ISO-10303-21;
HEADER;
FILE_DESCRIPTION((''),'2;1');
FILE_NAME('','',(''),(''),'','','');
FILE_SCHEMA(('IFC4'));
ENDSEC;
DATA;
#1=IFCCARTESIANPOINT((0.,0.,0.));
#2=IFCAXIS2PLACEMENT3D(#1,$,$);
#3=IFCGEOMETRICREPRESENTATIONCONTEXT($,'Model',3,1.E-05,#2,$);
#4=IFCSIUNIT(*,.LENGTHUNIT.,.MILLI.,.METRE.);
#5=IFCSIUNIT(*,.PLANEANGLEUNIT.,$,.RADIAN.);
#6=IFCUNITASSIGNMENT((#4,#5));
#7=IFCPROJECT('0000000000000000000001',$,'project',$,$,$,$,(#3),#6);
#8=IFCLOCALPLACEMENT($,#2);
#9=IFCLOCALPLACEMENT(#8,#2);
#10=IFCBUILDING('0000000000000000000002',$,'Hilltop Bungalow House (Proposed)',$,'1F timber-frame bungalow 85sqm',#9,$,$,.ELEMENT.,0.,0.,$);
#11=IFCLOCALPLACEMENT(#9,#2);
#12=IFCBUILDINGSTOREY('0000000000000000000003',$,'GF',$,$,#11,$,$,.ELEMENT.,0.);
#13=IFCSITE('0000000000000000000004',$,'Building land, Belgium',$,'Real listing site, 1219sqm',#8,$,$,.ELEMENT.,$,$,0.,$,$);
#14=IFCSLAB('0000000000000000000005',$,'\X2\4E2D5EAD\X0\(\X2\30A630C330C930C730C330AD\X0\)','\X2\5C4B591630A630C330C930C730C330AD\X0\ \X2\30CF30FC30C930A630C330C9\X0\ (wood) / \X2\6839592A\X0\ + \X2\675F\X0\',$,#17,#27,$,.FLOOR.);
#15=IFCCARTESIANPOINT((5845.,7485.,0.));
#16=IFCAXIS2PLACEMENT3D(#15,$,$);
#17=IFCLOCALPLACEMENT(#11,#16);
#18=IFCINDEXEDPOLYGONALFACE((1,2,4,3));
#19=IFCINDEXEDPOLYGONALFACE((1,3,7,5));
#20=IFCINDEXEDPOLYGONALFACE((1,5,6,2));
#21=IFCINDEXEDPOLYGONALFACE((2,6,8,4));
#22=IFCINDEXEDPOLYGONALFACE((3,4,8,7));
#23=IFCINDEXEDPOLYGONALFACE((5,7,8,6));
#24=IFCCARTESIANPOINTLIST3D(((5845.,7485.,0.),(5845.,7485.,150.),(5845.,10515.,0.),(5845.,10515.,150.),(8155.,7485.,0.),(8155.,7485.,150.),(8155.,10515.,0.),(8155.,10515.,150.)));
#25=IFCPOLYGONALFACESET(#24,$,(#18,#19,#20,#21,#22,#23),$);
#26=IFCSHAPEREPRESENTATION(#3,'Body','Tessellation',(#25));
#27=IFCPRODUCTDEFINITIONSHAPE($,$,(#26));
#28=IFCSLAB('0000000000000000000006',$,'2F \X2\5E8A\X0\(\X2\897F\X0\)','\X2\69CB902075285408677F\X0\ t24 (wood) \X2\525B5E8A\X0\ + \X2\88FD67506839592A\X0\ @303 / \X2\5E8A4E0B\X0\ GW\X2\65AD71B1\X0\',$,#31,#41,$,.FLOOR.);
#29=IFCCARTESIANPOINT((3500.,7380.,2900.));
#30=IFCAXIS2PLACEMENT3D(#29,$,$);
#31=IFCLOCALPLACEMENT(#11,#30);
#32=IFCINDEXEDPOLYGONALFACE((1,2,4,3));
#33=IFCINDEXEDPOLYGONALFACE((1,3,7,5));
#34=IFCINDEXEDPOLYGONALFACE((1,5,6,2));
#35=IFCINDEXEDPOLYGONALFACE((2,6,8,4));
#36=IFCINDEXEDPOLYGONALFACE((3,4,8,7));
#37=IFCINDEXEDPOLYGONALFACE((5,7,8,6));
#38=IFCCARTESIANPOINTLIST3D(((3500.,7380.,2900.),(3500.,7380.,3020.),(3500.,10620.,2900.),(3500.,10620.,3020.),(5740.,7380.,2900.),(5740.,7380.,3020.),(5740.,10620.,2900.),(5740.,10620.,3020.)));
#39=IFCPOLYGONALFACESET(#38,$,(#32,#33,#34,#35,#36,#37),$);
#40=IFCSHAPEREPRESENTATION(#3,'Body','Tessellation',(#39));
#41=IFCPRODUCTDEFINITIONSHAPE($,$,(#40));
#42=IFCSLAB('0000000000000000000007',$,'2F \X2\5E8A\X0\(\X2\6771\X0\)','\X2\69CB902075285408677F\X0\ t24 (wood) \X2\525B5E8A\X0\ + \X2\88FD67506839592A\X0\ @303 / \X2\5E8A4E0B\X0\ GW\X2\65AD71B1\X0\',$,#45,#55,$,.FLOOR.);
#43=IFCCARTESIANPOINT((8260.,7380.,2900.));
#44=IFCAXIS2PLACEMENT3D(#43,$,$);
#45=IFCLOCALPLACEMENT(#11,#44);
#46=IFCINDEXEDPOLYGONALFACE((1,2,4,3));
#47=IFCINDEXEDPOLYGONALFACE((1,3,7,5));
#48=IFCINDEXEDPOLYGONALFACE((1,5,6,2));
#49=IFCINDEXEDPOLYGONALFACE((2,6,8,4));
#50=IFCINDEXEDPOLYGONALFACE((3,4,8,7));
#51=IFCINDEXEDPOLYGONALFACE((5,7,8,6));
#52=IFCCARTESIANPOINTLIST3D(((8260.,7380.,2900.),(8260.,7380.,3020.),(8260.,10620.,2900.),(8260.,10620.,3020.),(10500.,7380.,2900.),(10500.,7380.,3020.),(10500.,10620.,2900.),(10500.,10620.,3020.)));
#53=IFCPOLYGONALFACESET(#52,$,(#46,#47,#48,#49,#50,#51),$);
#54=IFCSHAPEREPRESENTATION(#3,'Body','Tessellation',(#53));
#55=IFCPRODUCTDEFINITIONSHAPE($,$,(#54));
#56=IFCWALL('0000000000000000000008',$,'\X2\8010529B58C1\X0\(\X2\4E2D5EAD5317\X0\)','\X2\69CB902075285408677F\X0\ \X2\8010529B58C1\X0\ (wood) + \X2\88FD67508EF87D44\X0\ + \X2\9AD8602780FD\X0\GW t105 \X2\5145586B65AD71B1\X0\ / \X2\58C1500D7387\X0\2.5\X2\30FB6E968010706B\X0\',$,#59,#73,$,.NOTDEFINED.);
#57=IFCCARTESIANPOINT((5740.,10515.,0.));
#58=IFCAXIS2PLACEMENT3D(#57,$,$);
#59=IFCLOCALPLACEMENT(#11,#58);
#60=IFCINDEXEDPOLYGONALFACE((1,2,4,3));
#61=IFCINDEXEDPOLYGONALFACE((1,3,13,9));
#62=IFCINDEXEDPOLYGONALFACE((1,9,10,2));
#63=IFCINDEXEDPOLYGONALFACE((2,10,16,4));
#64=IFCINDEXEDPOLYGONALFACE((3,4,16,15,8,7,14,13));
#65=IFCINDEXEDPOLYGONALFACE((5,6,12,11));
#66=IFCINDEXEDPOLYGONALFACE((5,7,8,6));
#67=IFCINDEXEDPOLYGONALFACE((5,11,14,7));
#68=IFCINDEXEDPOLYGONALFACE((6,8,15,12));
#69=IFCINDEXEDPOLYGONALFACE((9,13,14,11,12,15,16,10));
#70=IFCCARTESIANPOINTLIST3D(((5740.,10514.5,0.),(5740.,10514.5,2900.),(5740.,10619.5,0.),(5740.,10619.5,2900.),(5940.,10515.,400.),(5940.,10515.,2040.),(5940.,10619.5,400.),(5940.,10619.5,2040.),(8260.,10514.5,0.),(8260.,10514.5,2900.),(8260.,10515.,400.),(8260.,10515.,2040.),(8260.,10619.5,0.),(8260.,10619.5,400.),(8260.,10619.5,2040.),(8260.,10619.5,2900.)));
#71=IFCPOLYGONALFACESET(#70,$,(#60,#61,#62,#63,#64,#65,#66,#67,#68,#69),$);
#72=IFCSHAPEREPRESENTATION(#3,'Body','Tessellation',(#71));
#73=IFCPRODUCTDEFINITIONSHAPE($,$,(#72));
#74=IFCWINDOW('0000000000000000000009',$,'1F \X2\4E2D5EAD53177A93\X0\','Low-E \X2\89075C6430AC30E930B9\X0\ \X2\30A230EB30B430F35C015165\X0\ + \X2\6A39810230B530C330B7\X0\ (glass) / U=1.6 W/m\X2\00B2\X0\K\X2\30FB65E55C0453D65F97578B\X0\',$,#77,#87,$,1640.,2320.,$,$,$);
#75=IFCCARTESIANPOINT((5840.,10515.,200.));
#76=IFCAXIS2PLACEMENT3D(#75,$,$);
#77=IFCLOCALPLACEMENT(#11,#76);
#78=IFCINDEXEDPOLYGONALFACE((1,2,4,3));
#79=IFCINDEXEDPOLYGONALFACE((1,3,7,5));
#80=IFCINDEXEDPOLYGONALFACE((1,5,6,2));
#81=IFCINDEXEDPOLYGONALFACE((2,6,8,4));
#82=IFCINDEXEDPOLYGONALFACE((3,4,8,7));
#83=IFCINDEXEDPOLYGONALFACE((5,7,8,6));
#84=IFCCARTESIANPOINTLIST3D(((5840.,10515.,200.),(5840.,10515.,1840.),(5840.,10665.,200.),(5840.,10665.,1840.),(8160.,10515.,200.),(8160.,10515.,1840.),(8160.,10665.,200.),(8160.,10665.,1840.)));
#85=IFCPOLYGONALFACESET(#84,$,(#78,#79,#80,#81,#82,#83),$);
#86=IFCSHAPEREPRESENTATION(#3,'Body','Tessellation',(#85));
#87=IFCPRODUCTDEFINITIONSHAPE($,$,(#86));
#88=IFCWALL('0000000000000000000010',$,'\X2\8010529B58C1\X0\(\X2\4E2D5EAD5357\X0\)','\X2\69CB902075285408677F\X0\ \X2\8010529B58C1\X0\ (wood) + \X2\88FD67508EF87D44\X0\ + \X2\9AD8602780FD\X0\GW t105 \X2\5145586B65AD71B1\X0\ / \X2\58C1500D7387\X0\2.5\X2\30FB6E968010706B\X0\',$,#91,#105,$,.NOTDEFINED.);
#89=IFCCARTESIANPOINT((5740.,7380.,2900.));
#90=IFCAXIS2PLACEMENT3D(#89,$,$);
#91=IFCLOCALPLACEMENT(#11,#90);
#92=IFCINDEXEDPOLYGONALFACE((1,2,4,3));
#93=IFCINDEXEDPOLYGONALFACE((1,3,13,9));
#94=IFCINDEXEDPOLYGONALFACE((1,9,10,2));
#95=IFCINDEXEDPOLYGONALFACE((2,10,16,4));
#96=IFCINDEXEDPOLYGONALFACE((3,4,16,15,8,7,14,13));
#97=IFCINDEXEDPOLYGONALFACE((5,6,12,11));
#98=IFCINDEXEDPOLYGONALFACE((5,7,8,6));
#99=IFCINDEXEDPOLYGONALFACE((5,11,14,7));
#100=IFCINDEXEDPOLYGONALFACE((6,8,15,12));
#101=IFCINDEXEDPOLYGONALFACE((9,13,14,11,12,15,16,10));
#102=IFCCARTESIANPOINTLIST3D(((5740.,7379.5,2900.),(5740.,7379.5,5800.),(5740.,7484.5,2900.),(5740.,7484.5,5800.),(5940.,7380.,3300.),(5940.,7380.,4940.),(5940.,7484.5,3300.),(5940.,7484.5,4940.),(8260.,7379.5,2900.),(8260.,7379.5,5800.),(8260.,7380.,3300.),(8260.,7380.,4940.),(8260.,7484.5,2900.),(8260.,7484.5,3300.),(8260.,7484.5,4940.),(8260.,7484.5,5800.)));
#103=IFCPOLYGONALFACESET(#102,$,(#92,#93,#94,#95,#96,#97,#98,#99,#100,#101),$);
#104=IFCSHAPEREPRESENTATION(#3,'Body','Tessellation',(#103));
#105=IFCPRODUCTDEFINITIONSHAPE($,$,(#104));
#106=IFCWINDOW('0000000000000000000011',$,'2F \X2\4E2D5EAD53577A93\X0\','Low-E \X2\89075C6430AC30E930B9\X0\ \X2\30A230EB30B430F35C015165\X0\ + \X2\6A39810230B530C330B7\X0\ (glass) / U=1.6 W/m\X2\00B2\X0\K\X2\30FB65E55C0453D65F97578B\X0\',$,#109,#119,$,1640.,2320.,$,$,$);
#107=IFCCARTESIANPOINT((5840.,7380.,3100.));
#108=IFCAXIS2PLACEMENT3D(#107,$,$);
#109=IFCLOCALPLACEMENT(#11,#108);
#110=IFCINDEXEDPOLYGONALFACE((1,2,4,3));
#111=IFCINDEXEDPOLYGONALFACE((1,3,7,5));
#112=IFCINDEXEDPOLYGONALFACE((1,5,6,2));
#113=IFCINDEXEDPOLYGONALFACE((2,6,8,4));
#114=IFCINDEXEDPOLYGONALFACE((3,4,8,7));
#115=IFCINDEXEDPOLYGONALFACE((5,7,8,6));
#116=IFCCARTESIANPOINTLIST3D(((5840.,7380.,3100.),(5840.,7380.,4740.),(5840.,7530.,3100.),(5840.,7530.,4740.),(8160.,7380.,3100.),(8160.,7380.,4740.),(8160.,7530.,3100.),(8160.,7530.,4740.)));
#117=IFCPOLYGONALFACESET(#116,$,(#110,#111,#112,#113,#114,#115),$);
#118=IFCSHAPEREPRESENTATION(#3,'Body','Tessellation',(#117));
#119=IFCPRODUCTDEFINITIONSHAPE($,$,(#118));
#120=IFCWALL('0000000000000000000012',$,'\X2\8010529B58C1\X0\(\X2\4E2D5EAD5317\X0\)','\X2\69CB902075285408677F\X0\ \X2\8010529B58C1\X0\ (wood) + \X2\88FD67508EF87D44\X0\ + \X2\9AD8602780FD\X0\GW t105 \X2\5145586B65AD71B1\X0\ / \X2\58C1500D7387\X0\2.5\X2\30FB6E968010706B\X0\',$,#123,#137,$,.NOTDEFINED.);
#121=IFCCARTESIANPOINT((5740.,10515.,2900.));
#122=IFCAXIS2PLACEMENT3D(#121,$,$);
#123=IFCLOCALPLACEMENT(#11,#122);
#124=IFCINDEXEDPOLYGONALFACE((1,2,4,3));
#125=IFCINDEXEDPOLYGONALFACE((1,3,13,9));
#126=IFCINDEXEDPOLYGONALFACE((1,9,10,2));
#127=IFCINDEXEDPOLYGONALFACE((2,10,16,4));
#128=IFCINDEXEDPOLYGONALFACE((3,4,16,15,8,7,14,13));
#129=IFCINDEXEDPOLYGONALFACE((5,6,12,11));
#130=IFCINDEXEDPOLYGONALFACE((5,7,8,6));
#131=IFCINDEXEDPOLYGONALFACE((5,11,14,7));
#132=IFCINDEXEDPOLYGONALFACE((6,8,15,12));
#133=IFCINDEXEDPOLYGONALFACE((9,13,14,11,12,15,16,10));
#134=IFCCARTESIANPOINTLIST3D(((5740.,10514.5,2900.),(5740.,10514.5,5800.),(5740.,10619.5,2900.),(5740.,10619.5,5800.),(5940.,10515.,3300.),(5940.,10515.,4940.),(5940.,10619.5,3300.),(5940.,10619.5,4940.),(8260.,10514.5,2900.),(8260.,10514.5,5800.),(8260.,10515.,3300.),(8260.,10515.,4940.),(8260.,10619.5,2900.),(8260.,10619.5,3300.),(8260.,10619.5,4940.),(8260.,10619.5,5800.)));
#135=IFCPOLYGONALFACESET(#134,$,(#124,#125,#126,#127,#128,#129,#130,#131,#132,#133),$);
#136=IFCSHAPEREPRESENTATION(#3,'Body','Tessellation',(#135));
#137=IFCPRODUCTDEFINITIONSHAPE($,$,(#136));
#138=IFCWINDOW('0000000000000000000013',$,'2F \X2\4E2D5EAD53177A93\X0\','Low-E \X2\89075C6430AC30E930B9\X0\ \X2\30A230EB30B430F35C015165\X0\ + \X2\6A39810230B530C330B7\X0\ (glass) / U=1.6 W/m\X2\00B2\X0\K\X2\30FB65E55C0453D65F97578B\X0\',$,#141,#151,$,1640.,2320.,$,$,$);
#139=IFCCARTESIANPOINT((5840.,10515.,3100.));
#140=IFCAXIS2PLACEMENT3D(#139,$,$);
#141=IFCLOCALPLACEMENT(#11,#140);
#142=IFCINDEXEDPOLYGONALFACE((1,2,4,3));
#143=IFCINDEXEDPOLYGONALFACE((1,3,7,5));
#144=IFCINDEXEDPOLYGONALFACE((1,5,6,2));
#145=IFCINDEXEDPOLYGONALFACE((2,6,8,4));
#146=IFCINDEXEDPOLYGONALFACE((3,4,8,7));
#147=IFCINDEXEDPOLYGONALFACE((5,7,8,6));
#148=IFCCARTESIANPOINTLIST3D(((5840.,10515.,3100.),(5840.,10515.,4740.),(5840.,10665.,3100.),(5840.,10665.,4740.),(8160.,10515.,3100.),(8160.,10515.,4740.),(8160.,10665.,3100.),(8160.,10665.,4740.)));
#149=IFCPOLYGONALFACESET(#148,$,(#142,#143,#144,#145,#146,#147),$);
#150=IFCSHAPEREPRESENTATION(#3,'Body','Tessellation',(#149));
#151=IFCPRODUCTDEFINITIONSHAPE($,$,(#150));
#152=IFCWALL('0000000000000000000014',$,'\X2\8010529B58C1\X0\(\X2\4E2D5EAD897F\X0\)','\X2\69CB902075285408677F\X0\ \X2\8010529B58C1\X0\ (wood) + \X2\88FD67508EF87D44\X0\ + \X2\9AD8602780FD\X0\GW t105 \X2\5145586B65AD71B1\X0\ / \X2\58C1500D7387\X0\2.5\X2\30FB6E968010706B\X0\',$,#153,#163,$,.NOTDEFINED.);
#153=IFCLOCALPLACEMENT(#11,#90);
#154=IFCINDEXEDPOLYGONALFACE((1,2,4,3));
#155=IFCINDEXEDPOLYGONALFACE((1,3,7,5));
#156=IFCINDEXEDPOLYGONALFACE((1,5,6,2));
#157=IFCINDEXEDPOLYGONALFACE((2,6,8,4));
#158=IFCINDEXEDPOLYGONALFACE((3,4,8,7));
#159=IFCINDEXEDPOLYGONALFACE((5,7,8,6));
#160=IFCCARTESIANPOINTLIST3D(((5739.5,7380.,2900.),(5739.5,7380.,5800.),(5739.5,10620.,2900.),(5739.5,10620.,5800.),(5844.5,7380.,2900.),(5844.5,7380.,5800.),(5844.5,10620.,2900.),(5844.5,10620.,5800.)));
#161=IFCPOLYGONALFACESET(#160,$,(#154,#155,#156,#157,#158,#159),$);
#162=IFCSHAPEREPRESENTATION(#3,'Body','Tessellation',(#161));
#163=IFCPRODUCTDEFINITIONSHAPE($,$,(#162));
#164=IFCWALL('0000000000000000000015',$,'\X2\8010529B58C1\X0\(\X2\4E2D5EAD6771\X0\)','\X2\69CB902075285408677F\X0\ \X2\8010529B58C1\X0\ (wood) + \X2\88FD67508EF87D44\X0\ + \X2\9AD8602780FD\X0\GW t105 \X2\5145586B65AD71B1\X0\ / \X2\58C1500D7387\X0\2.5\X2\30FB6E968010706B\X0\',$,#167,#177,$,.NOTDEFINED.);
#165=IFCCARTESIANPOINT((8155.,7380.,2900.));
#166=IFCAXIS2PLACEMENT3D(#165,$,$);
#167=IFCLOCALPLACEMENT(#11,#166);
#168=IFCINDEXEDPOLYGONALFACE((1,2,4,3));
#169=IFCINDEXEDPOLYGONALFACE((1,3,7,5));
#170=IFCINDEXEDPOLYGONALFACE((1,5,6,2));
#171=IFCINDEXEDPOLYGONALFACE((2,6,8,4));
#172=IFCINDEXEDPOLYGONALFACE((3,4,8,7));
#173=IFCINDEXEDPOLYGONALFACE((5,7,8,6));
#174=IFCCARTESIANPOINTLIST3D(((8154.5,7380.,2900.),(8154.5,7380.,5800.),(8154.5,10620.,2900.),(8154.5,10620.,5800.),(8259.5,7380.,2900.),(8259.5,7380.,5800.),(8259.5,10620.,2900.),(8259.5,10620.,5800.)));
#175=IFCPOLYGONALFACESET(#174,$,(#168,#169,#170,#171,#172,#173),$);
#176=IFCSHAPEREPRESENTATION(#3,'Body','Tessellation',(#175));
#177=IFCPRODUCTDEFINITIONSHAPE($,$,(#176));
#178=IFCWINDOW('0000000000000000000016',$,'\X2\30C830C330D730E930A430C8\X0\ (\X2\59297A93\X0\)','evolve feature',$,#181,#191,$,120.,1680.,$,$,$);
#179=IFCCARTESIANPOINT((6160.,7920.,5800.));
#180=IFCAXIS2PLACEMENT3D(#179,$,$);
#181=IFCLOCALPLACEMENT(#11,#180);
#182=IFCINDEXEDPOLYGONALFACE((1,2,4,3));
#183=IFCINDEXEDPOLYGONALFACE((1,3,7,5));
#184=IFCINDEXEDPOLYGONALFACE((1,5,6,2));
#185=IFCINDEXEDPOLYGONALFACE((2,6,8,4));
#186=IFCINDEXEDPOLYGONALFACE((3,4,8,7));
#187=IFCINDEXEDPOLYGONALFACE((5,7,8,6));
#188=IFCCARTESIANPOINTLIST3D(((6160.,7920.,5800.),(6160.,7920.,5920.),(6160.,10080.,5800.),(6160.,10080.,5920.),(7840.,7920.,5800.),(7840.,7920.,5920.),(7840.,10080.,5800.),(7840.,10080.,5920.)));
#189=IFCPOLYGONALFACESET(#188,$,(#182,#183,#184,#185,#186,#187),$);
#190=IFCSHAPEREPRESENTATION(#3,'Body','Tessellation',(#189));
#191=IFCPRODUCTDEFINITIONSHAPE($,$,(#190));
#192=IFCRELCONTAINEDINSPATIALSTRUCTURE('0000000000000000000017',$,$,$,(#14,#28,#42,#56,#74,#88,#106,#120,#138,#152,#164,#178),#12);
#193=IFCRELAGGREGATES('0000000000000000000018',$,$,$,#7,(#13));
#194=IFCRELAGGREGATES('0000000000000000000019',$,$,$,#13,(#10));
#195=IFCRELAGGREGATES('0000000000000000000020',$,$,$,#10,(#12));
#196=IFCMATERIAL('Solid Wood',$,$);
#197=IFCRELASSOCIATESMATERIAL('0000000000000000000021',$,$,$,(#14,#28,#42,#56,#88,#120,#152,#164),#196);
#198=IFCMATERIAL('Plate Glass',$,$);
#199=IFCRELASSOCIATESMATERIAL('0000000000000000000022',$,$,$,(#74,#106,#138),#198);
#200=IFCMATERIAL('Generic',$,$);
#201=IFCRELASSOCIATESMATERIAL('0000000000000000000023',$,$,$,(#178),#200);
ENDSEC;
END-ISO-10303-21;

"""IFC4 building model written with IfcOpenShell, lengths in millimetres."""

from ifc_helpers import new_model, si_unit, frame, frame_2d, origin, place, context, project, spatial, rectangle, extrude, material, element, fill, save


model = new_model("IFC4")

# Units and contexts
model_context = context("Model", 3, precision=1e-05, world=origin())
ifc_project = project(units=[si_unit("LENGTHUNIT", "METRE", prefix="MILLI"), si_unit("PLANEANGLEUNIT", "RADIAN")], contexts=[model_context])

# Site, building, storey
site_placement = place(None, origin())
site = spatial("IfcSite", under=ifc_project, at=site_placement, Name="Building land, Belgium", ObjectType="Real listing site, 1219sqm", CompositionType="ELEMENT", RefElevation=0.0)
building_placement = place(site_placement, origin())
building = spatial("IfcBuilding", under=site, at=building_placement, Name="Hilltop Bungalow House (Proposed)", ObjectType="1F timber-frame bungalow 85sqm", CompositionType="ELEMENT", ElevationOfRefHeight=0.0, ElevationOfTerrain=0.0)
storey_placement = place(building_placement, origin())
storey = spatial("IfcBuildingStorey", under=building, at=storey_placement, Name="GF", CompositionType="ELEMENT", Elevation=0.0)

# Slabs
ifc_material_1 = material(Name="Solid Wood")
slab_1_placement = place(storey_placement, frame((5845.0, 7485.0, 0.0)))
element("IfcSlab", 1, at=slab_1_placement, inside=storey, material=ifc_material_1, Name="中庭(ウッドデッキ)", Description="屋外ウッドデッキ ハードウッド (wood) / 根太 + 束", PredefinedType="FLOOR", context=model_context, shape_type="SweptSolid", body=[
    extrude(rectangle(XDim=2310.0, YDim=3030.0, at=frame_2d((1155.0, 1515.0))), frame((5845.0, 7485.0, 0.0)), (0.0, 0.0, 1.0), 150.0),
])
slab_2_placement = place(storey_placement, frame((3500.0, 7380.0, 2900.0)))
element("IfcSlab", 2, at=slab_2_placement, inside=storey, material=ifc_material_1, Name="2F 床(西)", Description="構造用合板 t24 (wood) 剛床 + 製材根太 @303 / 床下 GW断熱", PredefinedType="FLOOR", context=model_context, shape_type="SweptSolid", body=[
    extrude(rectangle(XDim=2240.0, YDim=3240.0, at=frame_2d((1120.0, 1620.0))), frame((3500.0, 7380.0, 2900.0)), (0.0, 0.0, 1.0), 120.0),
])
slab_3_placement = place(storey_placement, frame((8260.0, 7380.0, 2900.0)))
element("IfcSlab", 3, at=slab_3_placement, inside=storey, material=ifc_material_1, Name="2F 床(東)", Description="構造用合板 t24 (wood) 剛床 + 製材根太 @303 / 床下 GW断熱", PredefinedType="FLOOR", context=model_context, shape_type="SweptSolid", body=[
    extrude(rectangle(XDim=2240.0, YDim=3240.0, at=frame_2d((1120.0, 1620.0))), frame((8260.0, 7380.0, 2900.0)), (0.0, 0.0, 1.0), 120.0),
])

# Walls, openings, windows
wall_1_placement = place(storey_placement, frame((5740.0, 10515.0, 0.0)))
wall_1 = element("IfcWall", 4, at=wall_1_placement, inside=storey, material=ifc_material_1, Name="耐力壁(中庭北)", Description="構造用合板 耐力壁 (wood) + 製材軸組 + 高性能GW t105 充填断熱 / 壁倍率2.5・準耐火", PredefinedType="NOTDEFINED", context=model_context, shape_type="SweptSolid", body=[
    extrude(rectangle(XDim=2520.0, YDim=105.0, at=frame_2d((1260.0, 52.0))), frame((5740.0, 10515.0, 0.0)), (0.0, 0.0, 1.0), 2900.0),
])
opening_1_placement = place(storey_placement, frame((5840.0, 10515.0, 200.0)))
opening_1 = element("IfcOpeningElement", 5, at=opening_1_placement, cuts=wall_1, PredefinedType="NOTDEFINED", context=model_context, shape_type="SweptSolid", body=[
    extrude(rectangle(XDim=2320.0, YDim=150.0, at=frame_2d((1160.0, 75.0))), frame((5840.0, 10515.0, 200.0)), (0.0, 0.0, 1.0), 1640.0),
])
ifc_material_2 = material(Name="Plate Glass")
window_1_placement = place(storey_placement, frame((5840.0, 10515.0, 200.0)))
window_1 = element("IfcWindow", 6, at=window_1_placement, inside=storey, material=ifc_material_2, Name="1F 中庭北窓", Description="Low-E 複層ガラス アルゴン封入 + 樹脂サッシ (glass) / U=1.6 W/m²K・日射取得型", OverallHeight=1640.0, OverallWidth=2320.0, context=model_context, shape_type="SweptSolid", body=[
    extrude(rectangle(XDim=2320.0, YDim=150.0, at=frame_2d((1160.0, 75.0))), frame((5840.0, 10515.0, 200.0)), (0.0, 0.0, 1.0), 1640.0),
])
fill(opening_1, window_1)
wall_2_placement = place(storey_placement, frame((5740.0, 7380.0, 2900.0)))
wall_2 = element("IfcWall", 7, at=wall_2_placement, inside=storey, material=ifc_material_1, Name="耐力壁(中庭南)", Description="構造用合板 耐力壁 (wood) + 製材軸組 + 高性能GW t105 充填断熱 / 壁倍率2.5・準耐火", PredefinedType="NOTDEFINED", context=model_context, shape_type="SweptSolid", body=[
    extrude(rectangle(XDim=2520.0, YDim=105.0, at=frame_2d((1260.0, 52.0))), frame((5740.0, 7380.0, 2900.0)), (0.0, 0.0, 1.0), 2900.0),
])
opening_2_placement = place(storey_placement, frame((5840.0, 7380.0, 3100.0)))
opening_2 = element("IfcOpeningElement", 8, at=opening_2_placement, cuts=wall_2, PredefinedType="NOTDEFINED", context=model_context, shape_type="SweptSolid", body=[
    extrude(rectangle(XDim=2320.0, YDim=150.0, at=frame_2d((1160.0, 75.0))), frame((5840.0, 7380.0, 3100.0)), (0.0, 0.0, 1.0), 1640.0),
])
window_2_placement = place(storey_placement, frame((5840.0, 7380.0, 3100.0)))
window_2 = element("IfcWindow", 9, at=window_2_placement, inside=storey, material=ifc_material_2, Name="2F 中庭南窓", Description="Low-E 複層ガラス アルゴン封入 + 樹脂サッシ (glass) / U=1.6 W/m²K・日射取得型", OverallHeight=1640.0, OverallWidth=2320.0, context=model_context, shape_type="SweptSolid", body=[
    extrude(rectangle(XDim=2320.0, YDim=150.0, at=frame_2d((1160.0, 75.0))), frame((5840.0, 7380.0, 3100.0)), (0.0, 0.0, 1.0), 1640.0),
])
fill(opening_2, window_2)
wall_3_placement = place(storey_placement, frame((5740.0, 10515.0, 2900.0)))
wall_3 = element("IfcWall", 10, at=wall_3_placement, inside=storey, material=ifc_material_1, Name="耐力壁(中庭北)", Description="構造用合板 耐力壁 (wood) + 製材軸組 + 高性能GW t105 充填断熱 / 壁倍率2.5・準耐火", PredefinedType="NOTDEFINED", context=model_context, shape_type="SweptSolid", body=[
    extrude(rectangle(XDim=2520.0, YDim=105.0, at=frame_2d((1260.0, 52.0))), frame((5740.0, 10515.0, 2900.0)), (0.0, 0.0, 1.0), 2900.0),
])
opening_3_placement = place(storey_placement, frame((5840.0, 10515.0, 3100.0)))
opening_3 = element("IfcOpeningElement", 11, at=opening_3_placement, cuts=wall_3, PredefinedType="NOTDEFINED", context=model_context, shape_type="SweptSolid", body=[
    extrude(rectangle(XDim=2320.0, YDim=150.0, at=frame_2d((1160.0, 75.0))), frame((5840.0, 10515.0, 3100.0)), (0.0, 0.0, 1.0), 1640.0),
])
window_3_placement = place(storey_placement, frame((5840.0, 10515.0, 3100.0)))
window_3 = element("IfcWindow", 12, at=window_3_placement, inside=storey, material=ifc_material_2, Name="2F 中庭北窓", Description="Low-E 複層ガラス アルゴン封入 + 樹脂サッシ (glass) / U=1.6 W/m²K・日射取得型", OverallHeight=1640.0, OverallWidth=2320.0, context=model_context, shape_type="SweptSolid", body=[
    extrude(rectangle(XDim=2320.0, YDim=150.0, at=frame_2d((1160.0, 75.0))), frame((5840.0, 10515.0, 3100.0)), (0.0, 0.0, 1.0), 1640.0),
])
fill(opening_3, window_3)

# Walls
wall_4_placement = place(storey_placement, frame((5740.0, 7380.0, 2900.0)))
element("IfcWall", 13, at=wall_4_placement, inside=storey, material=ifc_material_1, Name="耐力壁(中庭西)", Description="構造用合板 耐力壁 (wood) + 製材軸組 + 高性能GW t105 充填断熱 / 壁倍率2.5・準耐火", PredefinedType="NOTDEFINED", context=model_context, shape_type="SweptSolid", body=[
    extrude(rectangle(XDim=105.0, YDim=3240.0, at=frame_2d((52.0, 1620.0))), frame((5740.0, 7380.0, 2900.0)), (0.0, 0.0, 1.0), 2900.0),
])
wall_5_placement = place(storey_placement, frame((8155.0, 7380.0, 2900.0)))
element("IfcWall", 14, at=wall_5_placement, inside=storey, material=ifc_material_1, Name="耐力壁(中庭東)", Description="構造用合板 耐力壁 (wood) + 製材軸組 + 高性能GW t105 充填断熱 / 壁倍率2.5・準耐火", PredefinedType="NOTDEFINED", context=model_context, shape_type="SweptSolid", body=[
    extrude(rectangle(XDim=105.0, YDim=3240.0, at=frame_2d((52.0, 1620.0))), frame((8155.0, 7380.0, 2900.0)), (0.0, 0.0, 1.0), 2900.0),
])

# Window
ifc_material_3 = material(Name="Generic")
window_4_placement = place(storey_placement, frame((6160.0, 7920.0, 5800.0)))
element("IfcWindow", 15, at=window_4_placement, inside=storey, material=ifc_material_3, Name="トップライト (天窓)", Description="evolve feature", OverallHeight=120.0, OverallWidth=1680.0, context=model_context, shape_type="SweptSolid", body=[
    extrude(rectangle(XDim=1680.0, YDim=2160.0, at=frame_2d((840.0, 1080.0))), frame((6160.0, 7920.0, 5800.0)), (0.0, 0.0, 1.0), 120.0),
])

save(model, "model.ifc")
